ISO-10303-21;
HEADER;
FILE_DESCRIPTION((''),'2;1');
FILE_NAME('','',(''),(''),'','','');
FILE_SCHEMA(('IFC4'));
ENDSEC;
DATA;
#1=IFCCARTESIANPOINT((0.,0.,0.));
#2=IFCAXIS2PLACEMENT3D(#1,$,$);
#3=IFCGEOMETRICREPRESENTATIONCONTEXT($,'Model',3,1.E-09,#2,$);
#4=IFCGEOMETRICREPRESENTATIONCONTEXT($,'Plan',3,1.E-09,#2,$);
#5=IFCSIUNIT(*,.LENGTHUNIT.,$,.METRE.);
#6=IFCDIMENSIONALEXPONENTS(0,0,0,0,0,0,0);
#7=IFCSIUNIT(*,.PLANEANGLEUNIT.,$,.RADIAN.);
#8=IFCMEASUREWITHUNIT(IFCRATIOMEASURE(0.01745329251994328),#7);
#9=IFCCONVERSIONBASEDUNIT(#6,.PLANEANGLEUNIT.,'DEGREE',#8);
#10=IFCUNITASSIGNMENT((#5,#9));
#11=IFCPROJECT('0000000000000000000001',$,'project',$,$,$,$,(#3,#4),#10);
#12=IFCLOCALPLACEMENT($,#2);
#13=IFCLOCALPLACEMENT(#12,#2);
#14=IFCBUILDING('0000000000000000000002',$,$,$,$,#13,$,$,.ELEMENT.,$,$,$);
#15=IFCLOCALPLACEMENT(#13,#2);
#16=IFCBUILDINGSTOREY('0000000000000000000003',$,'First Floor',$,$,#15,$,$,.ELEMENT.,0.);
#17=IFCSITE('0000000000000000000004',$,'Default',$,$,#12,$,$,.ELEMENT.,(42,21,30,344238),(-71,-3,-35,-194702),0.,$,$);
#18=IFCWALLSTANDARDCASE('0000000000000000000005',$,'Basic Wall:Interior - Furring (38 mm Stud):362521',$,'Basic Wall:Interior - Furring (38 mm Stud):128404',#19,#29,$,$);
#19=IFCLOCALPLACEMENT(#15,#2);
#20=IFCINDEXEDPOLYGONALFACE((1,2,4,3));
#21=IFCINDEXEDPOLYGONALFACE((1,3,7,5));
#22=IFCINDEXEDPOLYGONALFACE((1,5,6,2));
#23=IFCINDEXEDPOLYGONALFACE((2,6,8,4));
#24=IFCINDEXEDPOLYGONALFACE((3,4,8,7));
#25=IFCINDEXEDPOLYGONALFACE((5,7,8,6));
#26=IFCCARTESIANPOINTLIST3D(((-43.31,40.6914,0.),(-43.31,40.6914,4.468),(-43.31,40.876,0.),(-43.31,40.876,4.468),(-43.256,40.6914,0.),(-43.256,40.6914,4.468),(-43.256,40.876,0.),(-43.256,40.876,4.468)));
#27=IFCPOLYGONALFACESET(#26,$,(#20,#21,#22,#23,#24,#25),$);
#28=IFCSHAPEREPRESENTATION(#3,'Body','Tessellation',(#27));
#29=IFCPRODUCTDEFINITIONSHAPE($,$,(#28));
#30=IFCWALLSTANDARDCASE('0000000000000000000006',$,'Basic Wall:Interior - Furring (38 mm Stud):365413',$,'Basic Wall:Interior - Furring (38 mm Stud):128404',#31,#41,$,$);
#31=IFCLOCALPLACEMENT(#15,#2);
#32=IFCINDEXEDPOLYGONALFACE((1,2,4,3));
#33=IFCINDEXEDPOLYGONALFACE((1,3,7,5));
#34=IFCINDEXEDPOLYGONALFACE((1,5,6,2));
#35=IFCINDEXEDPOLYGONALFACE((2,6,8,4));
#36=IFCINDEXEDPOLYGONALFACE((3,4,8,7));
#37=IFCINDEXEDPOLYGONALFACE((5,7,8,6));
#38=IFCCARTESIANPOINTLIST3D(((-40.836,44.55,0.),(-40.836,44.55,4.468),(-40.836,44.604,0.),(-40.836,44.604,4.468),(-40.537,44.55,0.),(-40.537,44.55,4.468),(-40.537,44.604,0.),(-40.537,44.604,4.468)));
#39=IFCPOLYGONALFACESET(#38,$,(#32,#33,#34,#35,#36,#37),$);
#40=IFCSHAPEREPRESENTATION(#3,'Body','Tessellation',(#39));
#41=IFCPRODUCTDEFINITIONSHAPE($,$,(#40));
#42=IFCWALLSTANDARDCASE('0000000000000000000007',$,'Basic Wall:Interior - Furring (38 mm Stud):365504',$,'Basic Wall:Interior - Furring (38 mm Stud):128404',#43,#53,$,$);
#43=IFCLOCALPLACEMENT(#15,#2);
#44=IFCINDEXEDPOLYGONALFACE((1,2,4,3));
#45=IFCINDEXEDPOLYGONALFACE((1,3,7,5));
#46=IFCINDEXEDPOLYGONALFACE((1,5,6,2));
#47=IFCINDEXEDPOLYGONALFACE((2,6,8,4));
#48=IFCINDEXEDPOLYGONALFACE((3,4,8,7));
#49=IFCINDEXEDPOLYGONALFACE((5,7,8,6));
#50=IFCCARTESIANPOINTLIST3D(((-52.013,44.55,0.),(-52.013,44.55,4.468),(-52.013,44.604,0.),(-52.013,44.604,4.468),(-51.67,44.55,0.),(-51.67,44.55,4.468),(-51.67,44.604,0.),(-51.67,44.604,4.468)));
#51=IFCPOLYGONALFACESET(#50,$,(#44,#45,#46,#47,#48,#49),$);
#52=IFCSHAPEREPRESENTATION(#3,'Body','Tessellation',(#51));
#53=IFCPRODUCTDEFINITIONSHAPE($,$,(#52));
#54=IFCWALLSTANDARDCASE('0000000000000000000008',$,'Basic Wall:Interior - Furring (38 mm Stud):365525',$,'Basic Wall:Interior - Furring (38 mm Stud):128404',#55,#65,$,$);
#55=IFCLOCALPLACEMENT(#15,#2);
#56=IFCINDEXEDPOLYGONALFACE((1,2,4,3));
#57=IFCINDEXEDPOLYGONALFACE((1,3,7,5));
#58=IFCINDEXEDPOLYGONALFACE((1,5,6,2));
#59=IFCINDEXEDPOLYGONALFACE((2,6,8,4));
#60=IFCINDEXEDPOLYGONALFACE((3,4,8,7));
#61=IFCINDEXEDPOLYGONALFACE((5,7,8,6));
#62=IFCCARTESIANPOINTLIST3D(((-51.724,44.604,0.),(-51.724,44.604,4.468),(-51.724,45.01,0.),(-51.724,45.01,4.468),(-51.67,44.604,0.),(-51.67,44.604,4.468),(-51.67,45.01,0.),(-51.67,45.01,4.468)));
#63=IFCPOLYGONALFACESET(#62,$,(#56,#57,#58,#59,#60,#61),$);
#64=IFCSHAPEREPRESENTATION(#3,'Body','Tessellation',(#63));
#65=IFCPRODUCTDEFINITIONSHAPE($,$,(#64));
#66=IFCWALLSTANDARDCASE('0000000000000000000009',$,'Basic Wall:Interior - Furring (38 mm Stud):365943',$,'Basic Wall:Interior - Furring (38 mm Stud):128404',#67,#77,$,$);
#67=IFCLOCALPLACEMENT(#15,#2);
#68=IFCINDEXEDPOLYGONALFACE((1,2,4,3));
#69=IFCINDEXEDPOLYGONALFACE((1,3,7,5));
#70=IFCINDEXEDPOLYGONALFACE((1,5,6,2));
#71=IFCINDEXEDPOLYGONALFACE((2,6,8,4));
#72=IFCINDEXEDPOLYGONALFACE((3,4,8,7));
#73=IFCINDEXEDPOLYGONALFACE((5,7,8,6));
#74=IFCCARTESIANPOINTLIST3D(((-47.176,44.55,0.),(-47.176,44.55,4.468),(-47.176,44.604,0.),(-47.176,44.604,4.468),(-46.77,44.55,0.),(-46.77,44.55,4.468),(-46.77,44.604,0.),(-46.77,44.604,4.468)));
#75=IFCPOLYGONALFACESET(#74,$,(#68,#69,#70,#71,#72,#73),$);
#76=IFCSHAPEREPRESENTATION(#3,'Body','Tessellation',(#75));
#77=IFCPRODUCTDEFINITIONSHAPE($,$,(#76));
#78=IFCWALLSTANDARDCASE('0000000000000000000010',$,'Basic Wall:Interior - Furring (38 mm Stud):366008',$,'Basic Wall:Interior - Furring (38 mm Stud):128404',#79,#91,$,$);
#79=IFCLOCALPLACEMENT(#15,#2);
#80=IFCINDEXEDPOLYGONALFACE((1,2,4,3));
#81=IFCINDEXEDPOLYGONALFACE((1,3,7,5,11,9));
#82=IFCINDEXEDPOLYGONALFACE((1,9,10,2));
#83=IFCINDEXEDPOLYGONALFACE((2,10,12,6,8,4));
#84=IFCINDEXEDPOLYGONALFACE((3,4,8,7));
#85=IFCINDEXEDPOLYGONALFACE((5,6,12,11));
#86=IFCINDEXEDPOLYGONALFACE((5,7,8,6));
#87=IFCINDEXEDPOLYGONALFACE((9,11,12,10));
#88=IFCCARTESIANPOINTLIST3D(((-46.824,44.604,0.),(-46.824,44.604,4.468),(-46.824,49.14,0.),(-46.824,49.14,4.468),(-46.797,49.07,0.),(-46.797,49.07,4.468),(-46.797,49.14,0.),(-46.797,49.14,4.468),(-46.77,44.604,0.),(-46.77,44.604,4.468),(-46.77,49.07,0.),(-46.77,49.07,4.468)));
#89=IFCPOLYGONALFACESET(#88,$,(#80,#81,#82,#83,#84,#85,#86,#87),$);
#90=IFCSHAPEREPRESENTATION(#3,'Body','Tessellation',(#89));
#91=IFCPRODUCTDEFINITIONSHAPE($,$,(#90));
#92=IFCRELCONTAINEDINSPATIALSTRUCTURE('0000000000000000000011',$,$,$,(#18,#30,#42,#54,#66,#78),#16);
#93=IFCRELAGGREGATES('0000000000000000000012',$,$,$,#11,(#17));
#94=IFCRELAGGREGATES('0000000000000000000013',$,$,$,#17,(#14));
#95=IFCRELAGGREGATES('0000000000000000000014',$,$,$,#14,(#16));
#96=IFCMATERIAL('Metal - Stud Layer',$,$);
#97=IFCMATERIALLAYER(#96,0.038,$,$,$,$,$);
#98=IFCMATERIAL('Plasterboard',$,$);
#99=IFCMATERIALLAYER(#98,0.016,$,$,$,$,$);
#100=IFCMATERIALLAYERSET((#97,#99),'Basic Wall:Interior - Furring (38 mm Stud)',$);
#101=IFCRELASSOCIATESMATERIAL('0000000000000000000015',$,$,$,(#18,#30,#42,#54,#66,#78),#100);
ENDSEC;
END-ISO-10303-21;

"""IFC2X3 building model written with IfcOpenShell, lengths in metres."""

from ifc_helpers import new_model, entity, si_unit, converted_unit, frame, frame_2d, origin, place, context, project, spatial, polyline, rectangle, outline, extrude, material, layer, layer_set, layer_usage, element, save


model = new_model("IFC2X3")

# Units and contexts
model_context = context("Model", 3, precision=1e-09, world=origin())
plan_context = context("Plan", 3, precision=1e-09, world=origin())
ifc_project = project(units=[si_unit("LENGTHUNIT", "METRE"), converted_unit("PLANEANGLEUNIT", "DEGREE", entity("IfcRatioMeasure", 0.01745329251994328), si_unit("PLANEANGLEUNIT", "RADIAN"), dimensions=[0, 0, 0, 0, 0, 0, 0])], contexts=[model_context, plan_context])

# Site, building, storey
site_placement = place(None, origin())
site = spatial("IfcSite", under=ifc_project, at=site_placement, Name="Default", CompositionType="ELEMENT", RefLatitude=(42, 21, 30, 344238), RefLongitude=(-71, -3, -35, -194702), RefElevation=0.0)
building_placement = place(site_placement, origin())
building = spatial("IfcBuilding", under=site, at=building_placement, CompositionType="ELEMENT")
storey_placement = place(building_placement, origin())
storey = spatial("IfcBuildingStorey", under=building, at=storey_placement, Name="First Floor", CompositionType="ELEMENT", Elevation=0.0)

# Shared definitions
ifc_material_1 = material(Name="Plasterboard")
ifc_material_2 = material(Name="Metal - Stud Layer")

# Walls
ifc_layer_1 = layer(ifc_material_2, 0.038)
ifc_layer_2 = layer(ifc_material_1, 0.016)
ifc_layer_set_1 = layer_set([ifc_layer_1, ifc_layer_2], Name="Basic Wall:Interior - Furring (38 mm Stud)")
ifc_layer_usage_1 = layer_usage(ifc_layer_set_1, "AXIS2", "NEGATIVE", 0.027)
wall_1_placement = place(storey_placement, frame((-43.283, 40.876, 0.0), z_axis=(0.0, 0.0, 1.0), x_axis=(0.0, -1.0, 0.0)))
element("IfcWallStandardCase", 1, at=wall_1_placement, inside=storey, material=ifc_layer_usage_1, Name="Basic Wall:Interior - Furring (38 mm Stud):362521", ObjectType="Basic Wall:Interior - Furring (38 mm Stud):128404", context=model_context, shape_type="SweptSolid", body=[
    extrude(rectangle(XDim=0.1846, YDim=0.054, at=frame_2d((0.0923, 0.0), x_axis=(-1.0, 0.0))), origin(), (0.0, 0.0, 1.0), 4.468),
])
ifc_layer_usage_2 = layer_usage(ifc_layer_set_1, "AXIS2", "NEGATIVE", 0.027)
wall_2_placement = place(storey_placement, frame((-40.836, 44.577, 0.0)))
element("IfcWallStandardCase", 2, at=wall_2_placement, inside=storey, material=ifc_layer_usage_2, Name="Basic Wall:Interior - Furring (38 mm Stud):365413", ObjectType="Basic Wall:Interior - Furring (38 mm Stud):128404", context=model_context, shape_type="SweptSolid", body=[
    extrude(rectangle(XDim=0.299, YDim=0.054, at=frame_2d((0.1495, 0.0), x_axis=(-1.0, 0.0))), origin(), (0.0, 0.0, 1.0), 4.468),
])
ifc_layer_usage_3 = layer_usage(ifc_layer_set_1, "AXIS2", "NEGATIVE", 0.027)
wall_3_placement = place(storey_placement, frame((-52.013, 44.577, 0.0)))
element("IfcWallStandardCase", 3, at=wall_3_placement, inside=storey, material=ifc_layer_usage_3, Name="Basic Wall:Interior - Furring (38 mm Stud):365504", ObjectType="Basic Wall:Interior - Furring (38 mm Stud):128404", context=model_context, shape_type="SweptSolid", body=[
    extrude(rectangle(XDim=0.343, YDim=0.054, at=frame_2d((0.1715, 0.0), x_axis=(-1.0, 0.0))), origin(), (0.0, 0.0, 1.0), 4.468),
])
ifc_layer_usage_4 = layer_usage(ifc_layer_set_1, "AXIS2", "NEGATIVE", 0.027)
wall_4_placement = place(storey_placement, frame((-51.697, 44.604, 0.0), z_axis=(0.0, 0.0, 1.0), x_axis=(0.0, 1.0, 0.0)))
element("IfcWallStandardCase", 4, at=wall_4_placement, inside=storey, material=ifc_layer_usage_4, Name="Basic Wall:Interior - Furring (38 mm Stud):365525", ObjectType="Basic Wall:Interior - Furring (38 mm Stud):128404", context=model_context, shape_type="SweptSolid", body=[
    extrude(rectangle(XDim=0.406, YDim=0.054, at=frame_2d((0.203, 0.0), x_axis=(-1.0, 0.0))), origin(), (0.0, 0.0, 1.0), 4.468),
])
ifc_layer_usage_5 = layer_usage(ifc_layer_set_1, "AXIS2", "NEGATIVE", 0.027)
wall_5_placement = place(storey_placement, frame((-47.176, 44.577, 0.0)))
element("IfcWallStandardCase", 5, at=wall_5_placement, inside=storey, material=ifc_layer_usage_5, Name="Basic Wall:Interior - Furring (38 mm Stud):365943", ObjectType="Basic Wall:Interior - Furring (38 mm Stud):128404", context=model_context, shape_type="SweptSolid", body=[
    extrude(rectangle(XDim=0.406, YDim=0.054, at=frame_2d((0.203, 0.0), x_axis=(-1.0, 0.0))), origin(), (0.0, 0.0, 1.0), 4.468),
])
ifc_layer_usage_6 = layer_usage(ifc_layer_set_1, "AXIS2", "NEGATIVE", 0.027)
wall_6_placement = place(storey_placement, frame((-46.797, 44.604, 0.0), z_axis=(0.0, 0.0, 1.0), x_axis=(0.0, 1.0, 0.0)))
element("IfcWallStandardCase", 6, at=wall_6_placement, inside=storey, material=ifc_layer_usage_6, Name="Basic Wall:Interior - Furring (38 mm Stud):366008", ObjectType="Basic Wall:Interior - Furring (38 mm Stud):128404", context=model_context, shape_type="SweptSolid", body=[
    extrude(outline(polyline([(4.466, -0.027), (4.466, 0.0), (4.536, 0.0), (4.536, 0.027), (0.0, 0.027), (0.0, -0.027), (4.466, -0.027)])), origin(), (0.0, 0.0, 1.0), 4.468),
])

save(model, "model.ifc")
